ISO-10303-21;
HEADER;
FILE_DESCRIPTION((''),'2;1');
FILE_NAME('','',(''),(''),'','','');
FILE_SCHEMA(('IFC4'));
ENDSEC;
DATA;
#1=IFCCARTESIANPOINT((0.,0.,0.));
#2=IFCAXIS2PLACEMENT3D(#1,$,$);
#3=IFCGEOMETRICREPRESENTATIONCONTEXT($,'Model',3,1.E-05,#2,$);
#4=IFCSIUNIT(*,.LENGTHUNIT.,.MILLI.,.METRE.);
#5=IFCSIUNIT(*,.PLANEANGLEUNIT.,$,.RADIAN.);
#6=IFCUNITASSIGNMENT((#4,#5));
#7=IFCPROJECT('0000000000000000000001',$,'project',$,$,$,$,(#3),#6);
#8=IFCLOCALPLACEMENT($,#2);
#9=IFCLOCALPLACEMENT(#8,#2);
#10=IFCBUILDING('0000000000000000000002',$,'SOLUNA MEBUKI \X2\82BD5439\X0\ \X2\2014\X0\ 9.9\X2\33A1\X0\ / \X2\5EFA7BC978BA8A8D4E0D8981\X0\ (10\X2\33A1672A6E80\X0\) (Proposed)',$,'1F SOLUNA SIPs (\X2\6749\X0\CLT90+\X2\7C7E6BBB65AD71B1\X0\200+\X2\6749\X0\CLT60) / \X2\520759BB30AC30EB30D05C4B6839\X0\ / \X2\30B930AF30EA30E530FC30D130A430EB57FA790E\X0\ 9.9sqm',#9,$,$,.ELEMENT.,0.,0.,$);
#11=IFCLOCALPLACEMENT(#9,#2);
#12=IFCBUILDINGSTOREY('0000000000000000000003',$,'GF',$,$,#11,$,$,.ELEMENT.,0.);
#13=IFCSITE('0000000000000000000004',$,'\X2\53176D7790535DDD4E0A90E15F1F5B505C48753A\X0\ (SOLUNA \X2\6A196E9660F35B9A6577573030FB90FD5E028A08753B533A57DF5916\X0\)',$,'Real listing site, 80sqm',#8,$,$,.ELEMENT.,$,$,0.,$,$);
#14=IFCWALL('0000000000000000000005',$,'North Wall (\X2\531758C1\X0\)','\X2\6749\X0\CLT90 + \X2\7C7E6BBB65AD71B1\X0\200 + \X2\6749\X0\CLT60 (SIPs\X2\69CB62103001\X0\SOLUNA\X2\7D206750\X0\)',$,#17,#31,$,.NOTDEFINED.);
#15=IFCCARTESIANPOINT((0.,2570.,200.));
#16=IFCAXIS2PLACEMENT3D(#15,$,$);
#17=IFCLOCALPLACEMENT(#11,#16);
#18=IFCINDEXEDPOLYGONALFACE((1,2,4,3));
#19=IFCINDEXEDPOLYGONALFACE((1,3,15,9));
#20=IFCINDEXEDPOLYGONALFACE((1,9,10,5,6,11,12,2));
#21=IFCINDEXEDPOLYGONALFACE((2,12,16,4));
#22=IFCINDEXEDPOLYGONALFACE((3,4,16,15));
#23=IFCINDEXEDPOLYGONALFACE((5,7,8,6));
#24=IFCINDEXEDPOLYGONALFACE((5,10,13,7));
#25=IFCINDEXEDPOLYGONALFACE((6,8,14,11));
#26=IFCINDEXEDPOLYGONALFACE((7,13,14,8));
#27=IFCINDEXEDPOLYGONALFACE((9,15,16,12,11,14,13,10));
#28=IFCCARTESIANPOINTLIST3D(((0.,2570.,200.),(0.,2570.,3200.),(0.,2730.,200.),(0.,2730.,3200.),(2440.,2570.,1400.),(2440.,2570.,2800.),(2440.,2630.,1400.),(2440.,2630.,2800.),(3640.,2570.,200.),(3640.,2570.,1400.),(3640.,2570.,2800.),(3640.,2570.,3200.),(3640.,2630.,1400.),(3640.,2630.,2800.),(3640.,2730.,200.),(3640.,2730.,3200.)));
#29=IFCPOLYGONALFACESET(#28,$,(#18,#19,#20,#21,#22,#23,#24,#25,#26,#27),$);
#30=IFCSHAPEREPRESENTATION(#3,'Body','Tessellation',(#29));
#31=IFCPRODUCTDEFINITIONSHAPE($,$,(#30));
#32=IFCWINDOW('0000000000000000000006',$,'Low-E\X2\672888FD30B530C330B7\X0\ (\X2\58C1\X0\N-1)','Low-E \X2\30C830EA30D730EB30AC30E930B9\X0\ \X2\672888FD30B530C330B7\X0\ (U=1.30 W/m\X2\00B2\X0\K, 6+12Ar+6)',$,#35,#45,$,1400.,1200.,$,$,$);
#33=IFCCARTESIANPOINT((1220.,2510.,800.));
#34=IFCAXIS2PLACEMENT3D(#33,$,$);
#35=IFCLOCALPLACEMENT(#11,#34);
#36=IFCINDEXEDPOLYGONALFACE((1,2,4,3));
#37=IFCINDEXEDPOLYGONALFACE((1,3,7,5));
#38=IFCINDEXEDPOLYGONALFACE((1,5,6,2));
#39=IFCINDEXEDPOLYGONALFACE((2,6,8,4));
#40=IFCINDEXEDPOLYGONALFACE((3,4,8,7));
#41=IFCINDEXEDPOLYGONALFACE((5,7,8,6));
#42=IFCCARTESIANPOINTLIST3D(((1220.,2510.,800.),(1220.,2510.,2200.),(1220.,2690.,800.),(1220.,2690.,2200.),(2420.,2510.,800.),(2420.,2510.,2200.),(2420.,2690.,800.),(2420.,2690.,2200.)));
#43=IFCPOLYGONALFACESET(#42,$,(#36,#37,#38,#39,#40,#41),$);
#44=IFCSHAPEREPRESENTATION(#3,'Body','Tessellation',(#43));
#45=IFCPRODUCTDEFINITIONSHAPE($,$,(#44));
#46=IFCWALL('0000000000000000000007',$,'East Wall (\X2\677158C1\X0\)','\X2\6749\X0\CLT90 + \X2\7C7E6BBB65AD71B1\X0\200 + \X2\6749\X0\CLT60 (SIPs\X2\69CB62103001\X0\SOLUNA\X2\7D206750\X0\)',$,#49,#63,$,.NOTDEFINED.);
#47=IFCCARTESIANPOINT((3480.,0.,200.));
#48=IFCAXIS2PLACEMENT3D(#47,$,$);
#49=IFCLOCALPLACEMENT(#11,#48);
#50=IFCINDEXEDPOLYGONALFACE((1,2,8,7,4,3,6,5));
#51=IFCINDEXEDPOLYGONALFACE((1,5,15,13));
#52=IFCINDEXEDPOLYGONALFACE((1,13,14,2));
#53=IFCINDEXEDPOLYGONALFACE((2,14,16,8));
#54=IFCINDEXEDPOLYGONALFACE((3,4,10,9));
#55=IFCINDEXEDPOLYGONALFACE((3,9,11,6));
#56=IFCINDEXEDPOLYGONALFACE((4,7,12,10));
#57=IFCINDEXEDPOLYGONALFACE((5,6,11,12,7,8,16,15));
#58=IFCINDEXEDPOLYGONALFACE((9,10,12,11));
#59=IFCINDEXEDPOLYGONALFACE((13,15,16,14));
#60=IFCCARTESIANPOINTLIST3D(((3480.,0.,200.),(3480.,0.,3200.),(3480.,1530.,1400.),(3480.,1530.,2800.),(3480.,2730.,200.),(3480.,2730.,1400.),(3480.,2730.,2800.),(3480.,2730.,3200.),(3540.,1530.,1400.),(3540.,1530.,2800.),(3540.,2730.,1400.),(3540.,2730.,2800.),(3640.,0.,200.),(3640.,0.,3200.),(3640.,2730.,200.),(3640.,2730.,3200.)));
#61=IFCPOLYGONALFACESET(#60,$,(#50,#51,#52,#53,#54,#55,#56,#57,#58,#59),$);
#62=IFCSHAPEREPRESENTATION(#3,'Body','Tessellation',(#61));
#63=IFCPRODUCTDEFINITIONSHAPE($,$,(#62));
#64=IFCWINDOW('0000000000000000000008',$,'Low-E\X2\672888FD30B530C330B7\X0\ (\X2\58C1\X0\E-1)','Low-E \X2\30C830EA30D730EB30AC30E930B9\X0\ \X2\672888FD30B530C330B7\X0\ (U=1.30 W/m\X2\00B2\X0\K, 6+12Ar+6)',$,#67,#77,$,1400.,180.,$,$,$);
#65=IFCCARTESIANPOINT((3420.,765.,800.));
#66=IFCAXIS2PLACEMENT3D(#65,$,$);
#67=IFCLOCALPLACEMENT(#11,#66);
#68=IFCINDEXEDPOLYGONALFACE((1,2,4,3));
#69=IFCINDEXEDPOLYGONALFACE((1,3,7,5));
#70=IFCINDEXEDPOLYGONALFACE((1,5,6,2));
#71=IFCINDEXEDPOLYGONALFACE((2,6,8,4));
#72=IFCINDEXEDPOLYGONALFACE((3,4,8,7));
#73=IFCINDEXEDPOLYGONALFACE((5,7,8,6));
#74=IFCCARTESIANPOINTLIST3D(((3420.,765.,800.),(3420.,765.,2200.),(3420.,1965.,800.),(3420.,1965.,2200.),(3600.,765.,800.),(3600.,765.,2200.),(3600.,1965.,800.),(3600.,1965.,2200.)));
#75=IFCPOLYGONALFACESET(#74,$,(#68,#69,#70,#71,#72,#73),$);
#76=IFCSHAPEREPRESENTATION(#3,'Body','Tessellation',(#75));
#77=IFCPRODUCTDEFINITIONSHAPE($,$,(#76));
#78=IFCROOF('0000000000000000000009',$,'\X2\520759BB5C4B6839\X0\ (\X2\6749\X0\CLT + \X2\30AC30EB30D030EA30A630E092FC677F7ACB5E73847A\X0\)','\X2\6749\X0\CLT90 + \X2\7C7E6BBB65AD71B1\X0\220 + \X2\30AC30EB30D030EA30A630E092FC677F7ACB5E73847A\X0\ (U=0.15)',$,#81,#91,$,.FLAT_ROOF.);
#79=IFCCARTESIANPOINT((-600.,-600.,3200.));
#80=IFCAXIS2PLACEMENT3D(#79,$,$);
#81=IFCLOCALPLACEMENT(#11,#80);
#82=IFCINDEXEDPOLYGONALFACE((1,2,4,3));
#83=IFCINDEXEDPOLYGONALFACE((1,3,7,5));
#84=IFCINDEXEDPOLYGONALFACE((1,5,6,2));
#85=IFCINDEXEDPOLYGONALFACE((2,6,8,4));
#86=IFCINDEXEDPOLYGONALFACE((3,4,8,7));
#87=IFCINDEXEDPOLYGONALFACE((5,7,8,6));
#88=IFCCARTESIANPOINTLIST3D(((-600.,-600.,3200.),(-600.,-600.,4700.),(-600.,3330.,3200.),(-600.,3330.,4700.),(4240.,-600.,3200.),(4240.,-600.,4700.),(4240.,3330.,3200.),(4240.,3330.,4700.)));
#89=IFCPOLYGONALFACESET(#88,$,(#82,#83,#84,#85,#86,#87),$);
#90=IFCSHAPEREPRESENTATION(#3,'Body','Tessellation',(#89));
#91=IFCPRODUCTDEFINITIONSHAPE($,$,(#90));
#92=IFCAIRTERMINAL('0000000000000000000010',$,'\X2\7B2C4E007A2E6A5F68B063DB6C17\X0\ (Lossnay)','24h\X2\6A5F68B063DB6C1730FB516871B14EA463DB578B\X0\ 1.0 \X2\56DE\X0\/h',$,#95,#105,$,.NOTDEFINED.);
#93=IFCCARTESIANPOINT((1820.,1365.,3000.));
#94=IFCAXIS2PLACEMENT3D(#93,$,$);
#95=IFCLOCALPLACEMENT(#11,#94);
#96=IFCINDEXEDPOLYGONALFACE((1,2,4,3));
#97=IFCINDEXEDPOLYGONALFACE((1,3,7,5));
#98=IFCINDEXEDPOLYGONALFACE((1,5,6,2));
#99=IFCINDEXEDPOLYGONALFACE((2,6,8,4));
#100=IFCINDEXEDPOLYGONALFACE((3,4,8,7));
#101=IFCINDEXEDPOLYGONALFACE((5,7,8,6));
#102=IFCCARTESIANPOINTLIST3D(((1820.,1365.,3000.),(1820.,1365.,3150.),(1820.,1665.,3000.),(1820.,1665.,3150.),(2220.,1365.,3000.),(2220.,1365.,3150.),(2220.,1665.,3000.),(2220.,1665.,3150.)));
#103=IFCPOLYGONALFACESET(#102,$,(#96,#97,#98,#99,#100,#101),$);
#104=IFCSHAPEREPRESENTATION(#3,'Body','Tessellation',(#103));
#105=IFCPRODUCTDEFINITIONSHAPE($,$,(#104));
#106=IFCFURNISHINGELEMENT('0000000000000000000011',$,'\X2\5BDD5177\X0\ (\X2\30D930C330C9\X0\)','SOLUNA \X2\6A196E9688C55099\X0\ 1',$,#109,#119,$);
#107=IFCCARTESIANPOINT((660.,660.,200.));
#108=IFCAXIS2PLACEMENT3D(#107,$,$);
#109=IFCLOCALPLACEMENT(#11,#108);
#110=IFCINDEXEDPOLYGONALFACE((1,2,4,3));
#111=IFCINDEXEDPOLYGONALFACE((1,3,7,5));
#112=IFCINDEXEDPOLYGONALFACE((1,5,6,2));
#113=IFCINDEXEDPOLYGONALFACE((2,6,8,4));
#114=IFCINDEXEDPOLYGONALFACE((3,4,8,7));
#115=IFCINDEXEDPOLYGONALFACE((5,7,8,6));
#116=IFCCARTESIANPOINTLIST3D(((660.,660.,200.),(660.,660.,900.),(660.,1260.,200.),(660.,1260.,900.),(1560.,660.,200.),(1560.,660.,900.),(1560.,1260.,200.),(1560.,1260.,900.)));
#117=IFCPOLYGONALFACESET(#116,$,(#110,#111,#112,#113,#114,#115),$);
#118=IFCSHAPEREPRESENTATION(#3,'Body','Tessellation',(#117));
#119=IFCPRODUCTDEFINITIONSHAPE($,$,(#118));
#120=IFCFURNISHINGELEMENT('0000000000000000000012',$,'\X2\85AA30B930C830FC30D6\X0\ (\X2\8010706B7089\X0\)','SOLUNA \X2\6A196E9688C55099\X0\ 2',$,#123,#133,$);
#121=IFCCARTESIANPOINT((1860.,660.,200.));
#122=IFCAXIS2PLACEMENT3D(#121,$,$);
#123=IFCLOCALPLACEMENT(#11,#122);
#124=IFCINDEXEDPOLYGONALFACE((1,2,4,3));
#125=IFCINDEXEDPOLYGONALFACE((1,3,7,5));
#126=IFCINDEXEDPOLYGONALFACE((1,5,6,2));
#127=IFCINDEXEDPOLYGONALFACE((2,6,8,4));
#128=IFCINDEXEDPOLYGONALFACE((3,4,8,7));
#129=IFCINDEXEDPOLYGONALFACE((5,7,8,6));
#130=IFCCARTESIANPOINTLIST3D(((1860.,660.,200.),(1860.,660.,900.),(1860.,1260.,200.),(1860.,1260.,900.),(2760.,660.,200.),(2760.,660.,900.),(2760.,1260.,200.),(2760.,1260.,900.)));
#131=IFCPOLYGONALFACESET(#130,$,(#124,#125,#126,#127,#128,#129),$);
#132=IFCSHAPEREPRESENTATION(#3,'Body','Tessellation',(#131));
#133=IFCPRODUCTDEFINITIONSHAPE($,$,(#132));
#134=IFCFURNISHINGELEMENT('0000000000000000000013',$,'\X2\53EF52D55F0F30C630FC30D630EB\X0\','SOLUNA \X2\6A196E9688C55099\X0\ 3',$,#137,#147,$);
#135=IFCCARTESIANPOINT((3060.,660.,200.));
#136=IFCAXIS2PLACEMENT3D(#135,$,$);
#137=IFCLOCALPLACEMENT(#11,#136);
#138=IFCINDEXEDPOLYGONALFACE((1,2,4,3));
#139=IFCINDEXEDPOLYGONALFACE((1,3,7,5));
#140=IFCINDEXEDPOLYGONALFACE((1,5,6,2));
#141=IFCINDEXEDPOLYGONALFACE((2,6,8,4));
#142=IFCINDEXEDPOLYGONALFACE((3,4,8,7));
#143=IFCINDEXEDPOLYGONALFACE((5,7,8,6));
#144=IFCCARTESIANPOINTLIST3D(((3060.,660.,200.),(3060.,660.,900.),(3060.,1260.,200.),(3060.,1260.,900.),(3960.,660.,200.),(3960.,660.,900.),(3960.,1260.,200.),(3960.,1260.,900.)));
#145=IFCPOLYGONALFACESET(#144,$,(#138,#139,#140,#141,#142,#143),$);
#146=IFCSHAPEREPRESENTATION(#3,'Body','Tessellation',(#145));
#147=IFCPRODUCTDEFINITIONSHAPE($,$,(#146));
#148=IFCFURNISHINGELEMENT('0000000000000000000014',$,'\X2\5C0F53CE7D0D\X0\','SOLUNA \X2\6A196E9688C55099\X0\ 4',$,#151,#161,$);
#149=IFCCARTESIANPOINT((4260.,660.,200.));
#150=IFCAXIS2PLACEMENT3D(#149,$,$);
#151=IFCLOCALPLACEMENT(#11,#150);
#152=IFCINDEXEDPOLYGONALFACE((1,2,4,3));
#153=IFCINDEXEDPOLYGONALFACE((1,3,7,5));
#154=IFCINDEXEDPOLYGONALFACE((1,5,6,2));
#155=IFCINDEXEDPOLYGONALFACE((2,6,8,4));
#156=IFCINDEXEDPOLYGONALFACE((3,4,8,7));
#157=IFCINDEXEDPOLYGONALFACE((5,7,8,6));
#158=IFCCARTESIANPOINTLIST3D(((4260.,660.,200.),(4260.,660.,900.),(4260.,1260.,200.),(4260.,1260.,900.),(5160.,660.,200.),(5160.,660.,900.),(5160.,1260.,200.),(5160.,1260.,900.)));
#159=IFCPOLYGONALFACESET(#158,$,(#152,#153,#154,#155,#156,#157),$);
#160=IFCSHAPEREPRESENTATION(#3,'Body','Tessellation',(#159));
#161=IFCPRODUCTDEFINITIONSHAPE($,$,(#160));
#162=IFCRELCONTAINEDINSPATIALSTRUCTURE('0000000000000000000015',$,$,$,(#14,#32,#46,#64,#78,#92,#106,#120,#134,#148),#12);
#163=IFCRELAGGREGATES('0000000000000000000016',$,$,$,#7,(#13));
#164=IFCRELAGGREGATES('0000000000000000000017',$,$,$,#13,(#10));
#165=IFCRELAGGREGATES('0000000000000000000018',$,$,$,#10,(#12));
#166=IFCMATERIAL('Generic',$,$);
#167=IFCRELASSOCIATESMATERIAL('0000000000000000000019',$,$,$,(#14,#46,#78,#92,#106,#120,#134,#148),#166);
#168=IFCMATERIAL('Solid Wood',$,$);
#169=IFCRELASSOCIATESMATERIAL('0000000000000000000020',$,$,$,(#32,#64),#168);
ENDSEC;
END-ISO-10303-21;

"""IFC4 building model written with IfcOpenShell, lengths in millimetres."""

from ifc_helpers import new_model, si_unit, frame, frame_2d, origin, place, context, project, spatial, rectangle, extrude, material, element, fill, save


model = new_model("IFC4")

# Units and contexts
model_context = context("Model", 3, precision=1e-05, world=origin())
ifc_project = project(units=[si_unit("LENGTHUNIT", "METRE", prefix="MILLI"), si_unit("PLANEANGLEUNIT", "RADIAN")], contexts=[model_context])

# Site, building, storey
site_placement = place(None, origin())
site = spatial("IfcSite", under=ifc_project, at=site_placement, Name="北海道川上郡弟子屈町 (SOLUNA 標準想定敷地・都市計画区域外)", ObjectType="Real listing site, 80sqm", CompositionType="ELEMENT", RefElevation=0.0)
building_placement = place(site_placement, origin())
building = spatial("IfcBuilding", under=site, at=building_placement, Name="SOLUNA MEBUKI 芽吹 — 9.9㎡ / 建築確認不要 (10㎡未満) (Proposed)", ObjectType="1F SOLUNA SIPs (杉CLT90+籾殻断熱200+杉CLT60) / 切妻ガルバ屋根 / スクリューパイル基礎 9.9sqm", CompositionType="ELEMENT", ElevationOfRefHeight=0.0, ElevationOfTerrain=0.0)
storey_placement = place(building_placement, origin())
storey = spatial("IfcBuildingStorey", under=building, at=storey_placement, Name="GF", CompositionType="ELEMENT", Elevation=0.0)

# Shared definitions
ifc_material_1 = material(Name="Generic")

# Shared definitions
ifc_material_2 = material(Name="Solid Wood")

# Walls, openings, windows
wall_1_placement = place(storey_placement, frame((0.0, 2570.0, 200.0)))
wall_1 = element("IfcWall", 1, at=wall_1_placement, inside=storey, material=ifc_material_1, Name="North Wall (北壁)", Description="杉CLT90 + 籾殻断熱200 + 杉CLT60 (SIPs構成、SOLUNA素材)", PredefinedType="NOTDEFINED", context=model_context, shape_type="SweptSolid", body=[
    extrude(rectangle(XDim=3640.0, YDim=160.0, at=frame_2d((1820.0, 80.0))), frame((0.0, 2570.0, 200.0)), (0.0, 0.0, 1.0), 3000.0),
])
opening_1_placement = place(storey_placement, frame((1220.0, 2510.0, 800.0)))
opening_1 = element("IfcOpeningElement", 2, at=opening_1_placement, cuts=wall_1, PredefinedType="NOTDEFINED", context=model_context, shape_type="SweptSolid", body=[
    extrude(rectangle(XDim=1200.0, YDim=180.0, at=frame_2d((600.0, 90.0))), frame((1220.0, 2510.0, 800.0)), (0.0, 0.0, 1.0), 1400.0),
])
window_1_placement = place(storey_placement, frame((1220.0, 2510.0, 800.0)))
window_1 = element("IfcWindow", 3, at=window_1_placement, inside=storey, material=ifc_material_2, Name="Low-E木製サッシ (壁N-1)", Description="Low-E トリプルガラス 木製サッシ (U=1.30 W/m²K, 6+12Ar+6)", OverallHeight=1400.0, OverallWidth=1200.0, context=model_context, shape_type="SweptSolid", body=[
    extrude(rectangle(XDim=1200.0, YDim=180.0, at=frame_2d((600.0, 90.0))), frame((1220.0, 2510.0, 800.0)), (0.0, 0.0, 1.0), 1400.0),
])
fill(opening_1, window_1)
wall_2_placement = place(storey_placement, frame((3480.0, 0.0, 200.0)))
wall_2 = element("IfcWall", 4, at=wall_2_placement, inside=storey, material=ifc_material_1, Name="East Wall (東壁)", Description="杉CLT90 + 籾殻断熱200 + 杉CLT60 (SIPs構成、SOLUNA素材)", PredefinedType="NOTDEFINED", context=model_context, shape_type="SweptSolid", body=[
    extrude(rectangle(XDim=160.0, YDim=2730.0, at=frame_2d((80.0, 1365.0))), frame((3480.0, 0.0, 200.0)), (0.0, 0.0, 1.0), 3000.0),
])
opening_2_placement = place(storey_placement, frame((3420.0, 765.0, 800.0)))
opening_2 = element("IfcOpeningElement", 5, at=opening_2_placement, cuts=wall_2, PredefinedType="NOTDEFINED", context=model_context, shape_type="SweptSolid", body=[
    extrude(rectangle(XDim=180.0, YDim=1200.0, at=frame_2d((90.0, 600.0))), frame((3420.0, 765.0, 800.0)), (0.0, 0.0, 1.0), 1400.0),
])
window_2_placement = place(storey_placement, frame((3420.0, 765.0, 800.0)))
window_2 = element("IfcWindow", 6, at=window_2_placement, inside=storey, material=ifc_material_2, Name="Low-E木製サッシ (壁E-1)", Description="Low-E トリプルガラス 木製サッシ (U=1.30 W/m²K, 6+12Ar+6)", OverallHeight=1400.0, OverallWidth=180.0, context=model_context, shape_type="SweptSolid", body=[
    extrude(rectangle(XDim=180.0, YDim=1200.0, at=frame_2d((90.0, 600.0))), frame((3420.0, 765.0, 800.0)), (0.0, 0.0, 1.0), 1400.0),
])
fill(opening_2, window_2)

# Roof
roof_placement = place(storey_placement, frame((-600.0, -600.0, 3200.0)))
element("IfcRoof", 7, at=roof_placement, inside=storey, material=ifc_material_1, Name="切妻屋根 (杉CLT + ガルバリウム鋼板立平葺)", Description="杉CLT90 + 籾殻断熱220 + ガルバリウム鋼板立平葺 (U=0.15)", PredefinedType="FLAT_ROOF", context=model_context, shape_type="SweptSolid", body=[
    extrude(rectangle(XDim=4840.0, YDim=3930.0, at=frame_2d((2420.0, 1965.0))), frame((-600.0, -600.0, 3200.0)), (0.0, 0.0, 1.0), 1500.0),
])

# Air terminal
air_terminal_placement = place(storey_placement, frame((1820.0, 1365.0, 3000.0)))
element("IfcAirTerminal", 8, at=air_terminal_placement, inside=storey, material=ifc_material_1, Name="第一種機械換気 (Lossnay)", Description="24h機械換気・全熱交換型 1.0 回/h", PredefinedType="NOTDEFINED", context=model_context, shape_type="SweptSolid", body=[
    extrude(rectangle(XDim=400.0, YDim=300.0, at=frame_2d((200.0, 150.0))), frame((1820.0, 1365.0, 3000.0)), (0.0, 0.0, 1.0), 150.0),
])

# Furnishing elements
furnishing_1_placement = place(storey_placement, frame((660.0, 660.0, 200.0)))
element("IfcFurnishingElement", 9, at=furnishing_1_placement, inside=storey, material=ifc_material_1, Name="寝具 (ベッド)", Description="SOLUNA 標準装備 1", context=model_context, shape_type="SweptSolid", body=[
    extrude(rectangle(XDim=900.0, YDim=600.0, at=frame_2d((450.0, 300.0))), frame((660.0, 660.0, 200.0)), (0.0, 0.0, 1.0), 700.0),
])
furnishing_2_placement = place(storey_placement, frame((1860.0, 660.0, 200.0)))
element("IfcFurnishingElement", 10, at=furnishing_2_placement, inside=storey, material=ifc_material_1, Name="薪ストーブ (耐火炉)", Description="SOLUNA 標準装備 2", context=model_context, shape_type="SweptSolid", body=[
    extrude(rectangle(XDim=900.0, YDim=600.0, at=frame_2d((450.0, 300.0))), frame((1860.0, 660.0, 200.0)), (0.0, 0.0, 1.0), 700.0),
])
furnishing_3_placement = place(storey_placement, frame((3060.0, 660.0, 200.0)))
element("IfcFurnishingElement", 11, at=furnishing_3_placement, inside=storey, material=ifc_material_1, Name="可動式テーブル", Description="SOLUNA 標準装備 3", context=model_context, shape_type="SweptSolid", body=[
    extrude(rectangle(XDim=900.0, YDim=600.0, at=frame_2d((450.0, 300.0))), frame((3060.0, 660.0, 200.0)), (0.0, 0.0, 1.0), 700.0),
])
furnishing_4_placement = place(storey_placement, frame((4260.0, 660.0, 200.0)))
element("IfcFurnishingElement", 12, at=furnishing_4_placement, inside=storey, material=ifc_material_1, Name="小収納", Description="SOLUNA 標準装備 4", context=model_context, shape_type="SweptSolid", body=[
    extrude(rectangle(XDim=900.0, YDim=600.0, at=frame_2d((450.0, 300.0))), frame((4260.0, 660.0, 200.0)), (0.0, 0.0, 1.0), 700.0),
])

save(model, "model.ifc")
